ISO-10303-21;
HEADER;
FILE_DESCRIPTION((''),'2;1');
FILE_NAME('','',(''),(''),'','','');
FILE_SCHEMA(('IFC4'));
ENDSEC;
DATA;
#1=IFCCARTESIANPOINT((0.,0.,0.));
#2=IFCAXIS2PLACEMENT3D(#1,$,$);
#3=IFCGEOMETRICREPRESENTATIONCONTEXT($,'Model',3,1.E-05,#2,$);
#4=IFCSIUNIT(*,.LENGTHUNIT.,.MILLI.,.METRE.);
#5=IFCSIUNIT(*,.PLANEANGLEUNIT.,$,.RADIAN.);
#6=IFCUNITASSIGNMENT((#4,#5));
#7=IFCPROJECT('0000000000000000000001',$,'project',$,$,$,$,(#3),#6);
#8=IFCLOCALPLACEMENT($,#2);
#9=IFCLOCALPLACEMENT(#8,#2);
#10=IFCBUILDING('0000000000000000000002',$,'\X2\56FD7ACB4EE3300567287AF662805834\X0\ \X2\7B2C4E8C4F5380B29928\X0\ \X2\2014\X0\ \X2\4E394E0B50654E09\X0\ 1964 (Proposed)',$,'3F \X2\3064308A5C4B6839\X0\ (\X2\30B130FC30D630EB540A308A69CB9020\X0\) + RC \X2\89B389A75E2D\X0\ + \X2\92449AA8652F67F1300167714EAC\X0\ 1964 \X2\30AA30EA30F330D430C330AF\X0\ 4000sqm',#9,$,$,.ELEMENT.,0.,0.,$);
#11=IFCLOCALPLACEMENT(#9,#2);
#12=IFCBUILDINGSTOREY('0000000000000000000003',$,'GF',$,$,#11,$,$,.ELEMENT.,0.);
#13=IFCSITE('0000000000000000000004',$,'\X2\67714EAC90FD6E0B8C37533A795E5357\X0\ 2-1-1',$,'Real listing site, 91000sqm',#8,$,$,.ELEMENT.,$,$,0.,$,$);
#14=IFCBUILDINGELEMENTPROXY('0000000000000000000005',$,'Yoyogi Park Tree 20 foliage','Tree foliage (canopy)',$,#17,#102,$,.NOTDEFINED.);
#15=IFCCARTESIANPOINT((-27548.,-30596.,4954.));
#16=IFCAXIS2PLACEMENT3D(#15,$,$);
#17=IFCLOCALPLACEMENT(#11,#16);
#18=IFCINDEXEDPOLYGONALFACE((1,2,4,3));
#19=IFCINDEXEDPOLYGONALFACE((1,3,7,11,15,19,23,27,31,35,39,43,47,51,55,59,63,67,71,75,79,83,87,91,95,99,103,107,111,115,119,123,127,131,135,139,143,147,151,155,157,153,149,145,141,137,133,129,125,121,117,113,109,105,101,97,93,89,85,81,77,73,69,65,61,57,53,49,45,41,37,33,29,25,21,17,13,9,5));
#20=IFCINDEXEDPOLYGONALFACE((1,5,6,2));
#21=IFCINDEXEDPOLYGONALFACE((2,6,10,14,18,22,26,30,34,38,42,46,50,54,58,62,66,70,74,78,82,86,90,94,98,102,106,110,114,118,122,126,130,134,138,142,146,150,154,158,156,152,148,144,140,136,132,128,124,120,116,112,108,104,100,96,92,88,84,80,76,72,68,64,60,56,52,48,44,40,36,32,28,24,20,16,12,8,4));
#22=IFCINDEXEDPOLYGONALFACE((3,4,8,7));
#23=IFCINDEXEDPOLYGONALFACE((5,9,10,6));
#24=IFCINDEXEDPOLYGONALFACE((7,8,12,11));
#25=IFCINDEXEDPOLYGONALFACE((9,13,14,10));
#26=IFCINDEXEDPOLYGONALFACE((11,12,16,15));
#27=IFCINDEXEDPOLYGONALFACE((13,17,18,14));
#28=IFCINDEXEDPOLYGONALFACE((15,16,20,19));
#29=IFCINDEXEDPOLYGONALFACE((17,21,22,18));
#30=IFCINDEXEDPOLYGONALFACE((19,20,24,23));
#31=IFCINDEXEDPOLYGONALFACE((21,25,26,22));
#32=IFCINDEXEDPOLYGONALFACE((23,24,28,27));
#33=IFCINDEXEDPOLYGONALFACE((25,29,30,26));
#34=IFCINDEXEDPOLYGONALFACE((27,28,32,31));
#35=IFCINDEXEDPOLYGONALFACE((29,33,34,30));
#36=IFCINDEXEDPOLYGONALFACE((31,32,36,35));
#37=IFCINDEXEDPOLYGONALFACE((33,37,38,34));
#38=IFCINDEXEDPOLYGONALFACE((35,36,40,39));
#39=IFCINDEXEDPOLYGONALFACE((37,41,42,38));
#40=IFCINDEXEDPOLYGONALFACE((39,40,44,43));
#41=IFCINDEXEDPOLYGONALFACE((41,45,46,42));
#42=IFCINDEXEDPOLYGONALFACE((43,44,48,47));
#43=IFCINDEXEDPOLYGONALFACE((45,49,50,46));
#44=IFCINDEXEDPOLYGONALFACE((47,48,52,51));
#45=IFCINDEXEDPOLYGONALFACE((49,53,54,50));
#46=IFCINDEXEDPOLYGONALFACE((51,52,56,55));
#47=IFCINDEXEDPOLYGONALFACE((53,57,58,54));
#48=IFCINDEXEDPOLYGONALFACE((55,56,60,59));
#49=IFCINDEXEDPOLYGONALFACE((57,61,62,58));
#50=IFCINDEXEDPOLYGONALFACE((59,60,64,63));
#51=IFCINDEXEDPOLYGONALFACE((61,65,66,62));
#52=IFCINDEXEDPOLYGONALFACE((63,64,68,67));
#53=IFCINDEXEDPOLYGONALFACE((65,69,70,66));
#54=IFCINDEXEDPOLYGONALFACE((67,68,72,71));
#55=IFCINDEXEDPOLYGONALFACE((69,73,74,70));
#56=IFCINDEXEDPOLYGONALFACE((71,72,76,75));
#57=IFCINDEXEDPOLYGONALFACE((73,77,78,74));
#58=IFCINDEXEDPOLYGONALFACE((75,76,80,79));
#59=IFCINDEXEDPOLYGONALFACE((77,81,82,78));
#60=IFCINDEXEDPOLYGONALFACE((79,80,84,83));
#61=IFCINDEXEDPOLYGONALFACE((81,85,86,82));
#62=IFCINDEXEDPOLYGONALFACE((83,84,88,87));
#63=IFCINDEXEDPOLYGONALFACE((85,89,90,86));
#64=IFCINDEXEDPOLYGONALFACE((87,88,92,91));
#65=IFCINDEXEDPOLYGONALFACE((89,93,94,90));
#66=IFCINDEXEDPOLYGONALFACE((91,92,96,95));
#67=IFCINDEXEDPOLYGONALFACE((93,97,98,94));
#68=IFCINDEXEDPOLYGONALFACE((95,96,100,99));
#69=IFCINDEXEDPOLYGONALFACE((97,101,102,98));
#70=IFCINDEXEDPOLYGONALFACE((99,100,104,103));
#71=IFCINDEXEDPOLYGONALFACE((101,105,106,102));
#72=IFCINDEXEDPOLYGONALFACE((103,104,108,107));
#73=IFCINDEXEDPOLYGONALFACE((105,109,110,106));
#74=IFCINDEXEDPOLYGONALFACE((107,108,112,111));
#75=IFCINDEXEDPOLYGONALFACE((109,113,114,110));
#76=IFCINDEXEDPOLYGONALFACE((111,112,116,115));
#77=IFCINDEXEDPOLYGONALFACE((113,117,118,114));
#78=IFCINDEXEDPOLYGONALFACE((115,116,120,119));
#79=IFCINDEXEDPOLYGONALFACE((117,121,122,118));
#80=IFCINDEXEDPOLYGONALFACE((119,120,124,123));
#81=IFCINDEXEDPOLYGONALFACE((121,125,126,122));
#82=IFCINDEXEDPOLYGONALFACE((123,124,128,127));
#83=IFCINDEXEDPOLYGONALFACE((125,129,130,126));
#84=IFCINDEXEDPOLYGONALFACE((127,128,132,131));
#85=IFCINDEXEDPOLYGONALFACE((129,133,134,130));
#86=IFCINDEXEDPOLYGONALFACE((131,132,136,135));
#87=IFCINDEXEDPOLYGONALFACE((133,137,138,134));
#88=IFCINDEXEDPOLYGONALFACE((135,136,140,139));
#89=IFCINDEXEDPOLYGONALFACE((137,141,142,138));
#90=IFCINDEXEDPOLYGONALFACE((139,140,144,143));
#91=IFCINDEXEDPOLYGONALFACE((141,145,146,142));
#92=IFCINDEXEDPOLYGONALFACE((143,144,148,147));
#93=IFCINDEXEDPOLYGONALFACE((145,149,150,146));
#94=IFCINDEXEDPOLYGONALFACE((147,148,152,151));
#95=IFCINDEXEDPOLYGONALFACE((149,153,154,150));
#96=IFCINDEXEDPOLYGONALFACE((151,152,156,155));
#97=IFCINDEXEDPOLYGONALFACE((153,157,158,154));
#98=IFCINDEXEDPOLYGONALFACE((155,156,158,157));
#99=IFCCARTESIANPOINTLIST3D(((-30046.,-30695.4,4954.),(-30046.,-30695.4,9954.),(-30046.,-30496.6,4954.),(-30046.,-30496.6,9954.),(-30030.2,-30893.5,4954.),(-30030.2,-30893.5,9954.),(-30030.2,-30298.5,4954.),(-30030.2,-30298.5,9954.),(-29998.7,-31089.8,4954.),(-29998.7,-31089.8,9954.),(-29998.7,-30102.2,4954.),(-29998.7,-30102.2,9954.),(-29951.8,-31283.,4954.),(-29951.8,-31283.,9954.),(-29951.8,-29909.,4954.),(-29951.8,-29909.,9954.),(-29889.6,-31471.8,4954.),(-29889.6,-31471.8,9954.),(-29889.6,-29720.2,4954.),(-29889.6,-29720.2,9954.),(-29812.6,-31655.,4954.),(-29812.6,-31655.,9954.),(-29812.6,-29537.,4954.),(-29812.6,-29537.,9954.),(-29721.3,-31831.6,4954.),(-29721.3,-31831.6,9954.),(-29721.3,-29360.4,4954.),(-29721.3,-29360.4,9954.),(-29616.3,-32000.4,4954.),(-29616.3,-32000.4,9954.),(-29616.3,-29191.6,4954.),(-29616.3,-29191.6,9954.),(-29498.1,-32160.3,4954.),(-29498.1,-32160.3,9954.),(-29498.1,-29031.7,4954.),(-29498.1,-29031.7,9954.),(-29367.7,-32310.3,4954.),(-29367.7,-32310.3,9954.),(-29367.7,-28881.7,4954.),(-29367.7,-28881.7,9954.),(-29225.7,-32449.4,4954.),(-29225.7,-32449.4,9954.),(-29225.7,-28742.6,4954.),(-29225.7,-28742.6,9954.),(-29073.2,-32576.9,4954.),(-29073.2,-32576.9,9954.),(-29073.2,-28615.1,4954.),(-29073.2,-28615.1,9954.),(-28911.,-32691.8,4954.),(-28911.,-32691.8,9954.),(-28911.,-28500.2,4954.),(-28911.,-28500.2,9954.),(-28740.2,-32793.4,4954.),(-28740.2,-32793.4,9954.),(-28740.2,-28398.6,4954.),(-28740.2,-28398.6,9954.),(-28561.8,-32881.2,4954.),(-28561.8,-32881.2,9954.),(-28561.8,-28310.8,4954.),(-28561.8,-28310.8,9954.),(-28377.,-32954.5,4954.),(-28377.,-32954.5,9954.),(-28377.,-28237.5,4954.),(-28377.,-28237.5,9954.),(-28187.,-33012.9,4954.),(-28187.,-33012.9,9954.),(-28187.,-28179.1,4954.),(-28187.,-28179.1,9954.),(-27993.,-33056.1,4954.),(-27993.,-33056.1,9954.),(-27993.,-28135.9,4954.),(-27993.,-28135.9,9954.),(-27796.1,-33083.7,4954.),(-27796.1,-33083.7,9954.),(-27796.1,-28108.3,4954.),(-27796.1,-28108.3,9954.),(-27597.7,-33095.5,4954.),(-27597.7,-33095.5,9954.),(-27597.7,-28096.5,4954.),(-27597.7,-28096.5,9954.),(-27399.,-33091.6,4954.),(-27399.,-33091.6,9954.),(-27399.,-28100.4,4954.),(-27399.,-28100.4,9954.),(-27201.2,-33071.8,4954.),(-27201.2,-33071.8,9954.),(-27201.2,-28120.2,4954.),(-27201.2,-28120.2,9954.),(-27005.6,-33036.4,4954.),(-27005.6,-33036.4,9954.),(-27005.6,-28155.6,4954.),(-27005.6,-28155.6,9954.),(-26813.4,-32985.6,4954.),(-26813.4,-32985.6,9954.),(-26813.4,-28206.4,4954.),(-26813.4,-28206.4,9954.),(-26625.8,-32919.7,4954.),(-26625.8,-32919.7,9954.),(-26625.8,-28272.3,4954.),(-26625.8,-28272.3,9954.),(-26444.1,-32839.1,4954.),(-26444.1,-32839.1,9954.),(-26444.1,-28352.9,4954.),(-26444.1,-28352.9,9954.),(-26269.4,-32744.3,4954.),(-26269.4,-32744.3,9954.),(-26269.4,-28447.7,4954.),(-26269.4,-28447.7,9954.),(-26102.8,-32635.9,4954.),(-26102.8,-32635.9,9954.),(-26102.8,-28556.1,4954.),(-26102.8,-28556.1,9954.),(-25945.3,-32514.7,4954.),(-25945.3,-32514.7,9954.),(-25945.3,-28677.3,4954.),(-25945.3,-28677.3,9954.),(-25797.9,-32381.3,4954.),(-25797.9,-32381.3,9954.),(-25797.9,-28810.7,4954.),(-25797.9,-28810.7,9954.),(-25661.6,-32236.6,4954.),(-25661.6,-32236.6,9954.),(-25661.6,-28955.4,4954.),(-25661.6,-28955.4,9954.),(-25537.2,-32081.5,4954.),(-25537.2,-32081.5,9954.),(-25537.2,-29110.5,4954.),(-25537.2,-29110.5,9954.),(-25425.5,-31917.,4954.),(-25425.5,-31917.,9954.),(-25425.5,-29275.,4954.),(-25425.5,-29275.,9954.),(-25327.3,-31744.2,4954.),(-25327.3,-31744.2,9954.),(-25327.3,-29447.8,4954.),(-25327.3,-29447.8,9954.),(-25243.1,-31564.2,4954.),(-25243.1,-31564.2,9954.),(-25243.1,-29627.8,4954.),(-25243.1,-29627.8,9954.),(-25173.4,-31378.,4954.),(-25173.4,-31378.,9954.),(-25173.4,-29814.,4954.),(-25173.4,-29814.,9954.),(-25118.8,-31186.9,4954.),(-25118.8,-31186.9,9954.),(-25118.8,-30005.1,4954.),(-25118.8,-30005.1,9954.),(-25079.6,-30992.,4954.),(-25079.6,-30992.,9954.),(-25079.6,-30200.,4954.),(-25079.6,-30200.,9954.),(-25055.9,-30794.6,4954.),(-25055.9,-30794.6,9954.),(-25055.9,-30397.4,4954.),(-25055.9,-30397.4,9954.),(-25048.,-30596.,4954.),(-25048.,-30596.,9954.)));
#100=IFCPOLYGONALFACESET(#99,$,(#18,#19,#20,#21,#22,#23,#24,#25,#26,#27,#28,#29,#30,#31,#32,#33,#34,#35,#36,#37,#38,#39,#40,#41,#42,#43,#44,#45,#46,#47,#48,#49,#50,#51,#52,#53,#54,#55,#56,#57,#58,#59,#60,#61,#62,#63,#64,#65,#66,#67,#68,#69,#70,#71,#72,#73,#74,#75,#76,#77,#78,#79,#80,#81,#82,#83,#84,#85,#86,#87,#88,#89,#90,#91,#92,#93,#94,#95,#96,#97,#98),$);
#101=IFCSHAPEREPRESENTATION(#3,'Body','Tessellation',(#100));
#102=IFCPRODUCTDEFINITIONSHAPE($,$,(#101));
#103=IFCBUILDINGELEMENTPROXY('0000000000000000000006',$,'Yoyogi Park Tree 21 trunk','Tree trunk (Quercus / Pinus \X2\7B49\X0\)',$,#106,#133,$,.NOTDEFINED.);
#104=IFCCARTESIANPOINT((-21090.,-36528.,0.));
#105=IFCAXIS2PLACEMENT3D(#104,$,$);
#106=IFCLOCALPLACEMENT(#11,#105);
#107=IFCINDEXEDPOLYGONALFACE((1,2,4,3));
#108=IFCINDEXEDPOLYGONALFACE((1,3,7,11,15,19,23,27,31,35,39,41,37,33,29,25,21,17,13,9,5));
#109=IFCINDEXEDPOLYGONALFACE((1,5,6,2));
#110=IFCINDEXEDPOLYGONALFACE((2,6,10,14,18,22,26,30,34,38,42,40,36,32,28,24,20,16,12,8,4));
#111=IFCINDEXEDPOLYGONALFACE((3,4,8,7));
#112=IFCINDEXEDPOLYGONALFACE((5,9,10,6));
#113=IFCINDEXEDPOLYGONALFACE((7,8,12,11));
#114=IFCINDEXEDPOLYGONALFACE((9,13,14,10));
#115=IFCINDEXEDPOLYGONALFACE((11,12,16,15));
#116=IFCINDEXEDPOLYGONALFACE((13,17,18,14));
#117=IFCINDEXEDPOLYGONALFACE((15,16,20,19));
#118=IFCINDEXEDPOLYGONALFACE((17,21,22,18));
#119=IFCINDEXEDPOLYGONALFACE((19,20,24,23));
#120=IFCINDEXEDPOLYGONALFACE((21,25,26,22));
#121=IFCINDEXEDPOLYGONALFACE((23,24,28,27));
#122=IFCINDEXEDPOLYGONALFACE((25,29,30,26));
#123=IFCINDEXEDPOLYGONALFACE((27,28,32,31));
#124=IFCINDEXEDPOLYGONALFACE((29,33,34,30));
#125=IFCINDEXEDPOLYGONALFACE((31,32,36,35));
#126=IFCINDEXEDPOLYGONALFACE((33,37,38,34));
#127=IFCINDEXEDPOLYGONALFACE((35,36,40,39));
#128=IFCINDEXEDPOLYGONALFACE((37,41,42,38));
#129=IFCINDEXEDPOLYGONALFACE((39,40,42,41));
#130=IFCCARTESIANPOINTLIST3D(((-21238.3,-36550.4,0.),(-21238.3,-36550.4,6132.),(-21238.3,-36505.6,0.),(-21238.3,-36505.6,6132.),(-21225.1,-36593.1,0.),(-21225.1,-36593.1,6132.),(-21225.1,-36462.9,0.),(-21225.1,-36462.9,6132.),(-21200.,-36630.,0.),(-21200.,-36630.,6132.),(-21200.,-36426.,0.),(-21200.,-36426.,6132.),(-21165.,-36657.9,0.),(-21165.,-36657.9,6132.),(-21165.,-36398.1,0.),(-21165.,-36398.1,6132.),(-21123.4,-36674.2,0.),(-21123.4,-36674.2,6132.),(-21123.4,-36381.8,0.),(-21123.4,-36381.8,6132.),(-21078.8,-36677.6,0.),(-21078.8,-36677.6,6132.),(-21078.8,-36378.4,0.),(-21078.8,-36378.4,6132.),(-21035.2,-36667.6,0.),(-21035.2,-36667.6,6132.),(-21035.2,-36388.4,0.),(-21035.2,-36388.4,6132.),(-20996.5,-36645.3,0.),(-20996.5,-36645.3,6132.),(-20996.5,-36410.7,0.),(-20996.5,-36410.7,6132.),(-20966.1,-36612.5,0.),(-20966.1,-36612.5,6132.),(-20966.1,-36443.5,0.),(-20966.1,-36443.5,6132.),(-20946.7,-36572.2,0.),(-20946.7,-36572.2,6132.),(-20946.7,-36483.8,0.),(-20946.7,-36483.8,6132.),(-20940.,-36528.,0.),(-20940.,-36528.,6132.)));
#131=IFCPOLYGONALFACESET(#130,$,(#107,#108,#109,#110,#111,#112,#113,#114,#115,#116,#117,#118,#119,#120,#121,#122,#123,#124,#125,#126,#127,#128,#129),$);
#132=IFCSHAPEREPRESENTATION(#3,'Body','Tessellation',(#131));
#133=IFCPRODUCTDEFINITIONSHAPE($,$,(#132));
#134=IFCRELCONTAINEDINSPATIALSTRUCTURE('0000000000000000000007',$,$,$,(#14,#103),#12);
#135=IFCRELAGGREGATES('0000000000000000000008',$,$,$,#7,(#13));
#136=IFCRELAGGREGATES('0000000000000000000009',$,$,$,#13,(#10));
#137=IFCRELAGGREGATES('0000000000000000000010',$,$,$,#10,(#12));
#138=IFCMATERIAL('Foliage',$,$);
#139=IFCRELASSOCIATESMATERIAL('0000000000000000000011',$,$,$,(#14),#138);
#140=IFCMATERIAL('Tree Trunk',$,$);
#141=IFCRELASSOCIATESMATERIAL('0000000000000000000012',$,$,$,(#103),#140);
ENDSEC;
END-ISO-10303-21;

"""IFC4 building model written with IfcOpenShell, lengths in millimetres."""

from ifc_helpers import new_model, si_unit, frame, origin, origin_2d, place, context, project, spatial, circle, extrude, material, element, save


model = new_model("IFC4")

# Units and contexts
model_context = context("Model", 3, precision=1e-05, world=origin())
ifc_project = project(units=[si_unit("LENGTHUNIT", "METRE", prefix="MILLI"), si_unit("PLANEANGLEUNIT", "RADIAN")], contexts=[model_context])

# Site, building, storey
site_placement = place(None, origin())
site = spatial("IfcSite", under=ifc_project, at=site_placement, Name="東京都渋谷区神南 2-1-1", ObjectType="Real listing site, 91000sqm", CompositionType="ELEMENT", RefElevation=0.0)
building_placement = place(site_placement, origin())
building = spatial("IfcBuilding", under=site, at=building_placement, Name="国立代々木競技場 第二体育館 — 丹下健三 1964 (Proposed)", ObjectType="3F つり屋根 (ケーブル吊り構造) + RC 観覧席 + 鉄骨支柱、東京 1964 オリンピック 4000sqm", CompositionType="ELEMENT", ElevationOfRefHeight=0.0, ElevationOfTerrain=0.0)
storey_placement = place(building_placement, origin())
storey = spatial("IfcBuildingStorey", under=building, at=storey_placement, Name="GF", CompositionType="ELEMENT", Elevation=0.0)

# Building element proxies
ifc_material_1 = material(Name="Tree Trunk")
ifc_material_2 = material(Name="Foliage")
proxy_1_placement = place(storey_placement, frame((-27548.0, -30596.0, 4954.0)))
element("IfcBuildingElementProxy", 1, at=proxy_1_placement, inside=storey, material=ifc_material_2, Name="Yoyogi Park Tree 20 foliage", Description="Tree foliage (canopy)", PredefinedType="NOTDEFINED", context=model_context, shape_type="SweptSolid", body=[
    extrude(circle(Radius=2500.0, at=origin_2d()), frame((-27548.0, -30596.0, 4954.0)), (0.0, 0.0, 1.0), 5000.0),
])
proxy_2_placement = place(storey_placement, frame((-21090.0, -36528.0, 0.0)))
element("IfcBuildingElementProxy", 2, at=proxy_2_placement, inside=storey, material=ifc_material_1, Name="Yoyogi Park Tree 21 trunk", Description="Tree trunk (Quercus / Pinus 等)", PredefinedType="NOTDEFINED", context=model_context, shape_type="SweptSolid", body=[
    extrude(circle(Radius=150.0, at=origin_2d()), frame((-21090.0, -36528.0, 0.0)), (0.0, 0.0, 1.0), 6132.0),
])

save(model, "model.ifc")
